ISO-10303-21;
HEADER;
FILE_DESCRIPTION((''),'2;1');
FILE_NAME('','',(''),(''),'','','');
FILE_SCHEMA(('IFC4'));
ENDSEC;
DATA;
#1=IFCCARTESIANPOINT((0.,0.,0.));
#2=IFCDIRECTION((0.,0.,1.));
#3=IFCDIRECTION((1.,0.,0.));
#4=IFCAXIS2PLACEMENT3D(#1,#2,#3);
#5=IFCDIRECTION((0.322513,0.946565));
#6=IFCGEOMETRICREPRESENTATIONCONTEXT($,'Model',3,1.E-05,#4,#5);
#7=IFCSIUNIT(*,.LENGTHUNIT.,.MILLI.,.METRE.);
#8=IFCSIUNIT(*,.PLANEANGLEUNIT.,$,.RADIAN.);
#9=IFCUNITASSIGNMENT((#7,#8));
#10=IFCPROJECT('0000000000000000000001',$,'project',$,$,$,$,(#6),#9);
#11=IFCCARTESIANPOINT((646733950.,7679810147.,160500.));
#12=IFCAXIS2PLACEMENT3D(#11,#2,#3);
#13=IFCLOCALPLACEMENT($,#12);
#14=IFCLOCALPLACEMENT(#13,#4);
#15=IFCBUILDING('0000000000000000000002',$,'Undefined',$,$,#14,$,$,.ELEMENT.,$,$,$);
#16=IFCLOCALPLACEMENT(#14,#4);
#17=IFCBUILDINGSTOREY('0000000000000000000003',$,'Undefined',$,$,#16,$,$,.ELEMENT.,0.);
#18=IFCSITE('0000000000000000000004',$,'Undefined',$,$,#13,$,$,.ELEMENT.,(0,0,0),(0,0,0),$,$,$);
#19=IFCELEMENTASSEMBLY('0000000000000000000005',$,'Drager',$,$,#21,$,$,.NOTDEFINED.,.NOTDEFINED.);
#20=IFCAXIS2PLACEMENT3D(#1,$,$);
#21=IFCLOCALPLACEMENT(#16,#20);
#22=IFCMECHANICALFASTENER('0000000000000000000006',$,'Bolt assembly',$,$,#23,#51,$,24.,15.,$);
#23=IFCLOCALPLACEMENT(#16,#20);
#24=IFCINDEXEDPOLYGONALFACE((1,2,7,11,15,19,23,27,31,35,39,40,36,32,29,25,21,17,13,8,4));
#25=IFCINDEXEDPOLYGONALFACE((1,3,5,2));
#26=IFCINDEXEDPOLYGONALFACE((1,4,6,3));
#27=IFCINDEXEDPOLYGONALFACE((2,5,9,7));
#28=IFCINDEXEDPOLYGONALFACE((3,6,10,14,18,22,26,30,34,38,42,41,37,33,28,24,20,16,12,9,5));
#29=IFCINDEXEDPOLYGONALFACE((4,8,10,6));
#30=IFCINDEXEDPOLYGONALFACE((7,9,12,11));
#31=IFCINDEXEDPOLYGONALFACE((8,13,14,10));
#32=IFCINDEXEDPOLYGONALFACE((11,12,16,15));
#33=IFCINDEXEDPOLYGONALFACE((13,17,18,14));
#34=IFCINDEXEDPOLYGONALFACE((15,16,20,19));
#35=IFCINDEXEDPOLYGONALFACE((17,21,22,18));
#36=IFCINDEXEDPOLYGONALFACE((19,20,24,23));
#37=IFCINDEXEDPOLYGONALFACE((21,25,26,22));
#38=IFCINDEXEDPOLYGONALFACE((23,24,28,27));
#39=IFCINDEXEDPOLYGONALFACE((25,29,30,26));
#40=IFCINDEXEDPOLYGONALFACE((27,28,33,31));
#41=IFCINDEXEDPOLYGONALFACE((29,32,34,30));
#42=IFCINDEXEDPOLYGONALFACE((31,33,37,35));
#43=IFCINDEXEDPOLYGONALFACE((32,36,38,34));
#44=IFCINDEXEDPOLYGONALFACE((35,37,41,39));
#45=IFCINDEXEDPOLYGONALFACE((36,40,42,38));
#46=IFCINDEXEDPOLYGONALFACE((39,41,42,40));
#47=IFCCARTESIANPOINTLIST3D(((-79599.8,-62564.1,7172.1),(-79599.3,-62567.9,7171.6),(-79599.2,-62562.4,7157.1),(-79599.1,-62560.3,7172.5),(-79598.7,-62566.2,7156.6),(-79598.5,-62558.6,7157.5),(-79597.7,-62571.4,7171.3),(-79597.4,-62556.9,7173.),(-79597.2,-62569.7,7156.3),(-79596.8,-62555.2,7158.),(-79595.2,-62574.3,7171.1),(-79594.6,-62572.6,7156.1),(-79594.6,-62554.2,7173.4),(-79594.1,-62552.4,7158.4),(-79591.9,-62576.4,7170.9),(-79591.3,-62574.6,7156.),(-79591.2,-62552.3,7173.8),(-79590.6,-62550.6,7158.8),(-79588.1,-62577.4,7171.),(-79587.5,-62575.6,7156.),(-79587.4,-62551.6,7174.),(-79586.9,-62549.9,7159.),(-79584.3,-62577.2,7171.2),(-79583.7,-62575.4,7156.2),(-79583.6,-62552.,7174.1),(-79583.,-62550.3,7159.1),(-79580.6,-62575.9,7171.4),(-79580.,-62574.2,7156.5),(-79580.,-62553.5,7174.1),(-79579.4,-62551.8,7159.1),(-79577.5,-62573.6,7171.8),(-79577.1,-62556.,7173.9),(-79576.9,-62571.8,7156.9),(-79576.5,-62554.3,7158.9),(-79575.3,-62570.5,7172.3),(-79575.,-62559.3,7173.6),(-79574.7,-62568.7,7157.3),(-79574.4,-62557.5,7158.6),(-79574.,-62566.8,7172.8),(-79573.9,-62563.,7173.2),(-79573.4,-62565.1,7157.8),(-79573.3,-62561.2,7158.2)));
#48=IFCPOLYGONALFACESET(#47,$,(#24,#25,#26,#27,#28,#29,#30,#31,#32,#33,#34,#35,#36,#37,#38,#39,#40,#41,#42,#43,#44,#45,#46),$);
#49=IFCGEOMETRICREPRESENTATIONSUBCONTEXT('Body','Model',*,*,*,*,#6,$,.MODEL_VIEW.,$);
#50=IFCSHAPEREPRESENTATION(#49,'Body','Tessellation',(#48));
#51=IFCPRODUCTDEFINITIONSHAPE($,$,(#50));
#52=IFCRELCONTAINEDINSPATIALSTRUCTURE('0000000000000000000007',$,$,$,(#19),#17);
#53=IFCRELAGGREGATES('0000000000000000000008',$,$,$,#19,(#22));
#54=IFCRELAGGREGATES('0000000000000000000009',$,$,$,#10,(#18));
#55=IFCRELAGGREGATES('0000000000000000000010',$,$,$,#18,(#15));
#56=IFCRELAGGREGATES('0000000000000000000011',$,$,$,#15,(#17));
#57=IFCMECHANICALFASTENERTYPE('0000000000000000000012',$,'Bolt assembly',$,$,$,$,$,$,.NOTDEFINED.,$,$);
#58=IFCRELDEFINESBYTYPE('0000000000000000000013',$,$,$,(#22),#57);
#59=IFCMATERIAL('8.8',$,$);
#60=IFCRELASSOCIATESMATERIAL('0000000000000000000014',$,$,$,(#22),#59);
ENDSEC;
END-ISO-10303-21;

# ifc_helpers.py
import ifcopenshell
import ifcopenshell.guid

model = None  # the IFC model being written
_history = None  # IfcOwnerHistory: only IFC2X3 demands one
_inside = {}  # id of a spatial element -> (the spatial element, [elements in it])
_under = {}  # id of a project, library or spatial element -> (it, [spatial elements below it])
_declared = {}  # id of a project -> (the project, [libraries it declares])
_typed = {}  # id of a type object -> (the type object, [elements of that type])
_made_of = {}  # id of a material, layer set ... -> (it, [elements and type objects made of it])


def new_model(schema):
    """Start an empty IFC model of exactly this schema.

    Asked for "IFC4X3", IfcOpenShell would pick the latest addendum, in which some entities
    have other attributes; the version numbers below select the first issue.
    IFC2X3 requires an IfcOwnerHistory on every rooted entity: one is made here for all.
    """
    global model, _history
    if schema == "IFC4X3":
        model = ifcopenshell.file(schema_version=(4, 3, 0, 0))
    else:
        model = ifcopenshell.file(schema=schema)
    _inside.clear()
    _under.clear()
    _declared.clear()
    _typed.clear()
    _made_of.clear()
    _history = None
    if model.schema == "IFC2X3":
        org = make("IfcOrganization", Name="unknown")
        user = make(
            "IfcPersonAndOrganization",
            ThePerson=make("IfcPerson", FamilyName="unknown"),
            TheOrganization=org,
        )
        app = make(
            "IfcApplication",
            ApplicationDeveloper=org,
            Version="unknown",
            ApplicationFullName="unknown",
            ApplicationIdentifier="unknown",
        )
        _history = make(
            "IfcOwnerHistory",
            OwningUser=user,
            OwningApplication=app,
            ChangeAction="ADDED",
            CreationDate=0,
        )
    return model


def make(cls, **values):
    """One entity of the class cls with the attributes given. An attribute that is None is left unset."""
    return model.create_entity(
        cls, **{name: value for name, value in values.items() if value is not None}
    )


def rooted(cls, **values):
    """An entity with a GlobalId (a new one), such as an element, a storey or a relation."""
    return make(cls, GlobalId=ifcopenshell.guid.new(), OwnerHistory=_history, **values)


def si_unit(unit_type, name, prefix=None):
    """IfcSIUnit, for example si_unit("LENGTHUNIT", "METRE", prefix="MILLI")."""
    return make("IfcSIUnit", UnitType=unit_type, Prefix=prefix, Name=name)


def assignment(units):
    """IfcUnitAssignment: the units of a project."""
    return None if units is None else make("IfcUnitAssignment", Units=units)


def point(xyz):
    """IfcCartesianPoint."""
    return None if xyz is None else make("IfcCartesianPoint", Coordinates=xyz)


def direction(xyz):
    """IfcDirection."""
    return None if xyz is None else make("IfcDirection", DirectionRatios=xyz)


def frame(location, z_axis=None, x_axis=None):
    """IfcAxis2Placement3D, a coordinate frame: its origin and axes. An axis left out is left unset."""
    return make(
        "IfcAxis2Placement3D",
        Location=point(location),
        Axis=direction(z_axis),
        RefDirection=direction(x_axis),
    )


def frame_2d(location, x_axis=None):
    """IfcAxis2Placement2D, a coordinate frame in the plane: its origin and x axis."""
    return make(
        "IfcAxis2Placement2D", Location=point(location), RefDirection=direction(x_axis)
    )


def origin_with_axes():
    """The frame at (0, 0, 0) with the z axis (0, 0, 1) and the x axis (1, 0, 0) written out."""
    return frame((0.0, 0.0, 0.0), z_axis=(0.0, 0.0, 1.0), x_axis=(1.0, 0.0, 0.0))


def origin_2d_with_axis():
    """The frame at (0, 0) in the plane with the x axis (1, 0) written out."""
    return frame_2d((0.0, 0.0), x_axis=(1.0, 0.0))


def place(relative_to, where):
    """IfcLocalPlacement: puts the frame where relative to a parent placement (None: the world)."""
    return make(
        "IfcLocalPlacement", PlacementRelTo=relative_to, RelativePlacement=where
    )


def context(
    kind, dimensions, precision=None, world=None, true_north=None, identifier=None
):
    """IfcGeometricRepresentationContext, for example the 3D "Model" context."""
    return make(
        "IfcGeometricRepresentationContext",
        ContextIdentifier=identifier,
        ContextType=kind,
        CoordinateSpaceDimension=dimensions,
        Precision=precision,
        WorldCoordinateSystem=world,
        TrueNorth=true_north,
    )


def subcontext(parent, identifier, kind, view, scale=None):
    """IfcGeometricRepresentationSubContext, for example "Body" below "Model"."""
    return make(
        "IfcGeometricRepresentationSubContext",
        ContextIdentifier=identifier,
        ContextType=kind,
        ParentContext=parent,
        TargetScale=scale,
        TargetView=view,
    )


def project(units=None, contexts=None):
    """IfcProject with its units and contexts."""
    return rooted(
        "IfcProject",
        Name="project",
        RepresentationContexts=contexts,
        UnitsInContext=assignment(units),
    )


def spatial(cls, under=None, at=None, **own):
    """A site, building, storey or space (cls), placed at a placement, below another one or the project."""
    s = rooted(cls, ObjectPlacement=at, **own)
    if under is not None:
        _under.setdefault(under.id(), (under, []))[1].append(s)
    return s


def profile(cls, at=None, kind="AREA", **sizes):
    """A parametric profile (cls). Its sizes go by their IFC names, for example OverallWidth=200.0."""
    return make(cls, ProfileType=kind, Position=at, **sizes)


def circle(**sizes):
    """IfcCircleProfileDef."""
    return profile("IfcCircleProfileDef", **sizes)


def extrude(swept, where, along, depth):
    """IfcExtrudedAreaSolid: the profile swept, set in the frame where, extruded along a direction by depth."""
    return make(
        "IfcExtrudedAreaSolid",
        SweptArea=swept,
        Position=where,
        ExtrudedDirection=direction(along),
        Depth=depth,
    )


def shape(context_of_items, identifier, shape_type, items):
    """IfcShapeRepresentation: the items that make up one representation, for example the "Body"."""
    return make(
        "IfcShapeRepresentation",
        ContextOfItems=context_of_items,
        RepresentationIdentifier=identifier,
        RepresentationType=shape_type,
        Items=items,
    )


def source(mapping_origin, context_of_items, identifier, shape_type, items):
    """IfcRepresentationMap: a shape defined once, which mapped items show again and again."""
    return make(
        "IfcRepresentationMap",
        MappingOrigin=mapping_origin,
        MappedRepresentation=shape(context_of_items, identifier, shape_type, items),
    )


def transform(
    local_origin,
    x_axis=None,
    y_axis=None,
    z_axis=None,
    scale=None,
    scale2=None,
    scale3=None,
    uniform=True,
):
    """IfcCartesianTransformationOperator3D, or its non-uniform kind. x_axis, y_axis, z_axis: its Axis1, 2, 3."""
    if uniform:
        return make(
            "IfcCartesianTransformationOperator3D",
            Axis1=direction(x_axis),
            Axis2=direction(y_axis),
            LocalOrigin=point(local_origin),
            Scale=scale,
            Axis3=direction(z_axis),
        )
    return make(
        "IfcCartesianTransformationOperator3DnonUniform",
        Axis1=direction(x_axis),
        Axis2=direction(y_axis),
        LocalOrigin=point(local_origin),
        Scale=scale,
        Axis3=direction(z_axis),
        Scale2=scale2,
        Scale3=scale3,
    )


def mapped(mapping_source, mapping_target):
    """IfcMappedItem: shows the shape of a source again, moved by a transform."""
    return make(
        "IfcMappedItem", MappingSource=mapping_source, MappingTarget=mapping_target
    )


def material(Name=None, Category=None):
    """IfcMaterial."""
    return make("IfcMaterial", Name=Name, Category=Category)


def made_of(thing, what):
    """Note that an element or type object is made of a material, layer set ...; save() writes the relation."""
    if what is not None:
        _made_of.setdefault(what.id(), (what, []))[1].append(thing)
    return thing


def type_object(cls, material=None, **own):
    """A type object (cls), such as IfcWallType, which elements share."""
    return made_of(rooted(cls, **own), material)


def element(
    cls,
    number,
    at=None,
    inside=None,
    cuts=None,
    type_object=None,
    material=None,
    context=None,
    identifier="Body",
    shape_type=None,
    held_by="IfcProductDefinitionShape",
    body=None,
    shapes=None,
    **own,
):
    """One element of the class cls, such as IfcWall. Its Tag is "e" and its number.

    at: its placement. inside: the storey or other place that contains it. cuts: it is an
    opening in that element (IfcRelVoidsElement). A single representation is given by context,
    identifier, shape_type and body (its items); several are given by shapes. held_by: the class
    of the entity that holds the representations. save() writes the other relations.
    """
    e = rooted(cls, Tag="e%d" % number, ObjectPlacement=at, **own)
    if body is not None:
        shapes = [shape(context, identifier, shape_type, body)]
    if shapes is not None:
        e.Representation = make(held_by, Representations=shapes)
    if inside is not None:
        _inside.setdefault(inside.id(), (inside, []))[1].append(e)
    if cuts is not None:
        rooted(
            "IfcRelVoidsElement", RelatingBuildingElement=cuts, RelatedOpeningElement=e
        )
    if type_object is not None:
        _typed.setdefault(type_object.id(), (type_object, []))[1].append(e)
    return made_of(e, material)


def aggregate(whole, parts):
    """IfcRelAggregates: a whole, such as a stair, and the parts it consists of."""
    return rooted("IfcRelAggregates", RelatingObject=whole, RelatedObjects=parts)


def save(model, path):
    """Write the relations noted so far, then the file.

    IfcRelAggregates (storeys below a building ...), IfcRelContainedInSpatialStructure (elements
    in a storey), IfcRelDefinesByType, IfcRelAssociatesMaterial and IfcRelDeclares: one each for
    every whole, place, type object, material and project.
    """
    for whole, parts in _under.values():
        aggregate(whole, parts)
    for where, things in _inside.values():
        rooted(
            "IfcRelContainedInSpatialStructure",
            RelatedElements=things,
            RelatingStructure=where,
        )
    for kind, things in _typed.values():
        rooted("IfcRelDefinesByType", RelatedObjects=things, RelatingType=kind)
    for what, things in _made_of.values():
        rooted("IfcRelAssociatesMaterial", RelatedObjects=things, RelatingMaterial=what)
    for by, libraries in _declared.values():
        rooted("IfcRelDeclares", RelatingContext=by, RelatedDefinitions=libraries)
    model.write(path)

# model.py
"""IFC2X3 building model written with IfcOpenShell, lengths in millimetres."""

from ifc_helpers import new_model, si_unit, direction, frame, origin_with_axes, origin_2d_with_axis, place, context, subcontext, project, spatial, circle, extrude, source, transform, mapped, material, type_object, element, aggregate, save


model = new_model("IFC2X3")

# Units and contexts
model_context = context("Model", 3, precision=1e-05, world=origin_with_axes(), true_north=direction((0.322513, 0.946565)))
body_context = subcontext(model_context, "Body", "Model", "MODEL_VIEW")
ifc_project = project(units=[si_unit("LENGTHUNIT", "METRE", prefix="MILLI"), si_unit("PLANEANGLEUNIT", "RADIAN")], contexts=[model_context])

# Site, building, storey
site_placement = place(None, frame((646733950.0, 7679810147.0, 160500.0), z_axis=(0.0, 0.0, 1.0), x_axis=(1.0, 0.0, 0.0)))
site = spatial("IfcSite", under=ifc_project, at=site_placement, Name="Undefined", CompositionType="ELEMENT", RefLatitude=(0, 0, 0), RefLongitude=(0, 0, 0))
building_placement = place(site_placement, origin_with_axes())
building = spatial("IfcBuilding", under=site, at=building_placement, Name="Undefined", CompositionType="ELEMENT")
storey_placement = place(building_placement, origin_with_axes())
storey = spatial("IfcBuildingStorey", under=building, at=storey_placement, Name="Undefined", CompositionType="ELEMENT", Elevation=0.0)

# Element assembly
assembly_1_placement = place(storey_placement, origin_with_axes())
assembly_1 = element("IfcElementAssembly", 1, at=assembly_1_placement, inside=storey, Name="Drager", AssemblyPlace="NOTDEFINED", PredefinedType="NOTDEFINED")

# Mechanical fastener
ifc_material_1 = material(Name="8.8")
mechanical_fastener_type = type_object("IfcMechanicalFastenerType", Name="Bolt assembly")
shared_shape_1 = source(origin_with_axes(), body_context, "Body", "SweptSolid", [
    extrude(circle(Radius=13.0, at=origin_2d_with_axis()), frame((0.0, -7.5, 0.0), z_axis=(0.0, 1.0, 0.0), x_axis=(1.0, 0.0, 0.0)), (0.0, 0.0, 1.0), 15.1),
])
mechanical_fastener_1_placement = place(assembly_1_placement, frame((-79586.5, -62563.6, 7165.1), z_axis=(-0.320109, -0.93951, -0.121869), x_axis=(-0.946565, 0.322513, 0.0)))
mechanical_fastener_1 = element("IfcMechanicalFastener", 2, at=mechanical_fastener_1_placement, type_object=mechanical_fastener_type, material=ifc_material_1, Name="Bolt assembly", NominalDiameter=24.0, NominalLength=15.0, context=body_context, shape_type="MappedRepresentation", body=[
    mapped(shared_shape_1, transform((0.0, 0.0, 0.0))),
])
aggregate(assembly_1, [mechanical_fastener_1])

save(model, "model.ifc")
